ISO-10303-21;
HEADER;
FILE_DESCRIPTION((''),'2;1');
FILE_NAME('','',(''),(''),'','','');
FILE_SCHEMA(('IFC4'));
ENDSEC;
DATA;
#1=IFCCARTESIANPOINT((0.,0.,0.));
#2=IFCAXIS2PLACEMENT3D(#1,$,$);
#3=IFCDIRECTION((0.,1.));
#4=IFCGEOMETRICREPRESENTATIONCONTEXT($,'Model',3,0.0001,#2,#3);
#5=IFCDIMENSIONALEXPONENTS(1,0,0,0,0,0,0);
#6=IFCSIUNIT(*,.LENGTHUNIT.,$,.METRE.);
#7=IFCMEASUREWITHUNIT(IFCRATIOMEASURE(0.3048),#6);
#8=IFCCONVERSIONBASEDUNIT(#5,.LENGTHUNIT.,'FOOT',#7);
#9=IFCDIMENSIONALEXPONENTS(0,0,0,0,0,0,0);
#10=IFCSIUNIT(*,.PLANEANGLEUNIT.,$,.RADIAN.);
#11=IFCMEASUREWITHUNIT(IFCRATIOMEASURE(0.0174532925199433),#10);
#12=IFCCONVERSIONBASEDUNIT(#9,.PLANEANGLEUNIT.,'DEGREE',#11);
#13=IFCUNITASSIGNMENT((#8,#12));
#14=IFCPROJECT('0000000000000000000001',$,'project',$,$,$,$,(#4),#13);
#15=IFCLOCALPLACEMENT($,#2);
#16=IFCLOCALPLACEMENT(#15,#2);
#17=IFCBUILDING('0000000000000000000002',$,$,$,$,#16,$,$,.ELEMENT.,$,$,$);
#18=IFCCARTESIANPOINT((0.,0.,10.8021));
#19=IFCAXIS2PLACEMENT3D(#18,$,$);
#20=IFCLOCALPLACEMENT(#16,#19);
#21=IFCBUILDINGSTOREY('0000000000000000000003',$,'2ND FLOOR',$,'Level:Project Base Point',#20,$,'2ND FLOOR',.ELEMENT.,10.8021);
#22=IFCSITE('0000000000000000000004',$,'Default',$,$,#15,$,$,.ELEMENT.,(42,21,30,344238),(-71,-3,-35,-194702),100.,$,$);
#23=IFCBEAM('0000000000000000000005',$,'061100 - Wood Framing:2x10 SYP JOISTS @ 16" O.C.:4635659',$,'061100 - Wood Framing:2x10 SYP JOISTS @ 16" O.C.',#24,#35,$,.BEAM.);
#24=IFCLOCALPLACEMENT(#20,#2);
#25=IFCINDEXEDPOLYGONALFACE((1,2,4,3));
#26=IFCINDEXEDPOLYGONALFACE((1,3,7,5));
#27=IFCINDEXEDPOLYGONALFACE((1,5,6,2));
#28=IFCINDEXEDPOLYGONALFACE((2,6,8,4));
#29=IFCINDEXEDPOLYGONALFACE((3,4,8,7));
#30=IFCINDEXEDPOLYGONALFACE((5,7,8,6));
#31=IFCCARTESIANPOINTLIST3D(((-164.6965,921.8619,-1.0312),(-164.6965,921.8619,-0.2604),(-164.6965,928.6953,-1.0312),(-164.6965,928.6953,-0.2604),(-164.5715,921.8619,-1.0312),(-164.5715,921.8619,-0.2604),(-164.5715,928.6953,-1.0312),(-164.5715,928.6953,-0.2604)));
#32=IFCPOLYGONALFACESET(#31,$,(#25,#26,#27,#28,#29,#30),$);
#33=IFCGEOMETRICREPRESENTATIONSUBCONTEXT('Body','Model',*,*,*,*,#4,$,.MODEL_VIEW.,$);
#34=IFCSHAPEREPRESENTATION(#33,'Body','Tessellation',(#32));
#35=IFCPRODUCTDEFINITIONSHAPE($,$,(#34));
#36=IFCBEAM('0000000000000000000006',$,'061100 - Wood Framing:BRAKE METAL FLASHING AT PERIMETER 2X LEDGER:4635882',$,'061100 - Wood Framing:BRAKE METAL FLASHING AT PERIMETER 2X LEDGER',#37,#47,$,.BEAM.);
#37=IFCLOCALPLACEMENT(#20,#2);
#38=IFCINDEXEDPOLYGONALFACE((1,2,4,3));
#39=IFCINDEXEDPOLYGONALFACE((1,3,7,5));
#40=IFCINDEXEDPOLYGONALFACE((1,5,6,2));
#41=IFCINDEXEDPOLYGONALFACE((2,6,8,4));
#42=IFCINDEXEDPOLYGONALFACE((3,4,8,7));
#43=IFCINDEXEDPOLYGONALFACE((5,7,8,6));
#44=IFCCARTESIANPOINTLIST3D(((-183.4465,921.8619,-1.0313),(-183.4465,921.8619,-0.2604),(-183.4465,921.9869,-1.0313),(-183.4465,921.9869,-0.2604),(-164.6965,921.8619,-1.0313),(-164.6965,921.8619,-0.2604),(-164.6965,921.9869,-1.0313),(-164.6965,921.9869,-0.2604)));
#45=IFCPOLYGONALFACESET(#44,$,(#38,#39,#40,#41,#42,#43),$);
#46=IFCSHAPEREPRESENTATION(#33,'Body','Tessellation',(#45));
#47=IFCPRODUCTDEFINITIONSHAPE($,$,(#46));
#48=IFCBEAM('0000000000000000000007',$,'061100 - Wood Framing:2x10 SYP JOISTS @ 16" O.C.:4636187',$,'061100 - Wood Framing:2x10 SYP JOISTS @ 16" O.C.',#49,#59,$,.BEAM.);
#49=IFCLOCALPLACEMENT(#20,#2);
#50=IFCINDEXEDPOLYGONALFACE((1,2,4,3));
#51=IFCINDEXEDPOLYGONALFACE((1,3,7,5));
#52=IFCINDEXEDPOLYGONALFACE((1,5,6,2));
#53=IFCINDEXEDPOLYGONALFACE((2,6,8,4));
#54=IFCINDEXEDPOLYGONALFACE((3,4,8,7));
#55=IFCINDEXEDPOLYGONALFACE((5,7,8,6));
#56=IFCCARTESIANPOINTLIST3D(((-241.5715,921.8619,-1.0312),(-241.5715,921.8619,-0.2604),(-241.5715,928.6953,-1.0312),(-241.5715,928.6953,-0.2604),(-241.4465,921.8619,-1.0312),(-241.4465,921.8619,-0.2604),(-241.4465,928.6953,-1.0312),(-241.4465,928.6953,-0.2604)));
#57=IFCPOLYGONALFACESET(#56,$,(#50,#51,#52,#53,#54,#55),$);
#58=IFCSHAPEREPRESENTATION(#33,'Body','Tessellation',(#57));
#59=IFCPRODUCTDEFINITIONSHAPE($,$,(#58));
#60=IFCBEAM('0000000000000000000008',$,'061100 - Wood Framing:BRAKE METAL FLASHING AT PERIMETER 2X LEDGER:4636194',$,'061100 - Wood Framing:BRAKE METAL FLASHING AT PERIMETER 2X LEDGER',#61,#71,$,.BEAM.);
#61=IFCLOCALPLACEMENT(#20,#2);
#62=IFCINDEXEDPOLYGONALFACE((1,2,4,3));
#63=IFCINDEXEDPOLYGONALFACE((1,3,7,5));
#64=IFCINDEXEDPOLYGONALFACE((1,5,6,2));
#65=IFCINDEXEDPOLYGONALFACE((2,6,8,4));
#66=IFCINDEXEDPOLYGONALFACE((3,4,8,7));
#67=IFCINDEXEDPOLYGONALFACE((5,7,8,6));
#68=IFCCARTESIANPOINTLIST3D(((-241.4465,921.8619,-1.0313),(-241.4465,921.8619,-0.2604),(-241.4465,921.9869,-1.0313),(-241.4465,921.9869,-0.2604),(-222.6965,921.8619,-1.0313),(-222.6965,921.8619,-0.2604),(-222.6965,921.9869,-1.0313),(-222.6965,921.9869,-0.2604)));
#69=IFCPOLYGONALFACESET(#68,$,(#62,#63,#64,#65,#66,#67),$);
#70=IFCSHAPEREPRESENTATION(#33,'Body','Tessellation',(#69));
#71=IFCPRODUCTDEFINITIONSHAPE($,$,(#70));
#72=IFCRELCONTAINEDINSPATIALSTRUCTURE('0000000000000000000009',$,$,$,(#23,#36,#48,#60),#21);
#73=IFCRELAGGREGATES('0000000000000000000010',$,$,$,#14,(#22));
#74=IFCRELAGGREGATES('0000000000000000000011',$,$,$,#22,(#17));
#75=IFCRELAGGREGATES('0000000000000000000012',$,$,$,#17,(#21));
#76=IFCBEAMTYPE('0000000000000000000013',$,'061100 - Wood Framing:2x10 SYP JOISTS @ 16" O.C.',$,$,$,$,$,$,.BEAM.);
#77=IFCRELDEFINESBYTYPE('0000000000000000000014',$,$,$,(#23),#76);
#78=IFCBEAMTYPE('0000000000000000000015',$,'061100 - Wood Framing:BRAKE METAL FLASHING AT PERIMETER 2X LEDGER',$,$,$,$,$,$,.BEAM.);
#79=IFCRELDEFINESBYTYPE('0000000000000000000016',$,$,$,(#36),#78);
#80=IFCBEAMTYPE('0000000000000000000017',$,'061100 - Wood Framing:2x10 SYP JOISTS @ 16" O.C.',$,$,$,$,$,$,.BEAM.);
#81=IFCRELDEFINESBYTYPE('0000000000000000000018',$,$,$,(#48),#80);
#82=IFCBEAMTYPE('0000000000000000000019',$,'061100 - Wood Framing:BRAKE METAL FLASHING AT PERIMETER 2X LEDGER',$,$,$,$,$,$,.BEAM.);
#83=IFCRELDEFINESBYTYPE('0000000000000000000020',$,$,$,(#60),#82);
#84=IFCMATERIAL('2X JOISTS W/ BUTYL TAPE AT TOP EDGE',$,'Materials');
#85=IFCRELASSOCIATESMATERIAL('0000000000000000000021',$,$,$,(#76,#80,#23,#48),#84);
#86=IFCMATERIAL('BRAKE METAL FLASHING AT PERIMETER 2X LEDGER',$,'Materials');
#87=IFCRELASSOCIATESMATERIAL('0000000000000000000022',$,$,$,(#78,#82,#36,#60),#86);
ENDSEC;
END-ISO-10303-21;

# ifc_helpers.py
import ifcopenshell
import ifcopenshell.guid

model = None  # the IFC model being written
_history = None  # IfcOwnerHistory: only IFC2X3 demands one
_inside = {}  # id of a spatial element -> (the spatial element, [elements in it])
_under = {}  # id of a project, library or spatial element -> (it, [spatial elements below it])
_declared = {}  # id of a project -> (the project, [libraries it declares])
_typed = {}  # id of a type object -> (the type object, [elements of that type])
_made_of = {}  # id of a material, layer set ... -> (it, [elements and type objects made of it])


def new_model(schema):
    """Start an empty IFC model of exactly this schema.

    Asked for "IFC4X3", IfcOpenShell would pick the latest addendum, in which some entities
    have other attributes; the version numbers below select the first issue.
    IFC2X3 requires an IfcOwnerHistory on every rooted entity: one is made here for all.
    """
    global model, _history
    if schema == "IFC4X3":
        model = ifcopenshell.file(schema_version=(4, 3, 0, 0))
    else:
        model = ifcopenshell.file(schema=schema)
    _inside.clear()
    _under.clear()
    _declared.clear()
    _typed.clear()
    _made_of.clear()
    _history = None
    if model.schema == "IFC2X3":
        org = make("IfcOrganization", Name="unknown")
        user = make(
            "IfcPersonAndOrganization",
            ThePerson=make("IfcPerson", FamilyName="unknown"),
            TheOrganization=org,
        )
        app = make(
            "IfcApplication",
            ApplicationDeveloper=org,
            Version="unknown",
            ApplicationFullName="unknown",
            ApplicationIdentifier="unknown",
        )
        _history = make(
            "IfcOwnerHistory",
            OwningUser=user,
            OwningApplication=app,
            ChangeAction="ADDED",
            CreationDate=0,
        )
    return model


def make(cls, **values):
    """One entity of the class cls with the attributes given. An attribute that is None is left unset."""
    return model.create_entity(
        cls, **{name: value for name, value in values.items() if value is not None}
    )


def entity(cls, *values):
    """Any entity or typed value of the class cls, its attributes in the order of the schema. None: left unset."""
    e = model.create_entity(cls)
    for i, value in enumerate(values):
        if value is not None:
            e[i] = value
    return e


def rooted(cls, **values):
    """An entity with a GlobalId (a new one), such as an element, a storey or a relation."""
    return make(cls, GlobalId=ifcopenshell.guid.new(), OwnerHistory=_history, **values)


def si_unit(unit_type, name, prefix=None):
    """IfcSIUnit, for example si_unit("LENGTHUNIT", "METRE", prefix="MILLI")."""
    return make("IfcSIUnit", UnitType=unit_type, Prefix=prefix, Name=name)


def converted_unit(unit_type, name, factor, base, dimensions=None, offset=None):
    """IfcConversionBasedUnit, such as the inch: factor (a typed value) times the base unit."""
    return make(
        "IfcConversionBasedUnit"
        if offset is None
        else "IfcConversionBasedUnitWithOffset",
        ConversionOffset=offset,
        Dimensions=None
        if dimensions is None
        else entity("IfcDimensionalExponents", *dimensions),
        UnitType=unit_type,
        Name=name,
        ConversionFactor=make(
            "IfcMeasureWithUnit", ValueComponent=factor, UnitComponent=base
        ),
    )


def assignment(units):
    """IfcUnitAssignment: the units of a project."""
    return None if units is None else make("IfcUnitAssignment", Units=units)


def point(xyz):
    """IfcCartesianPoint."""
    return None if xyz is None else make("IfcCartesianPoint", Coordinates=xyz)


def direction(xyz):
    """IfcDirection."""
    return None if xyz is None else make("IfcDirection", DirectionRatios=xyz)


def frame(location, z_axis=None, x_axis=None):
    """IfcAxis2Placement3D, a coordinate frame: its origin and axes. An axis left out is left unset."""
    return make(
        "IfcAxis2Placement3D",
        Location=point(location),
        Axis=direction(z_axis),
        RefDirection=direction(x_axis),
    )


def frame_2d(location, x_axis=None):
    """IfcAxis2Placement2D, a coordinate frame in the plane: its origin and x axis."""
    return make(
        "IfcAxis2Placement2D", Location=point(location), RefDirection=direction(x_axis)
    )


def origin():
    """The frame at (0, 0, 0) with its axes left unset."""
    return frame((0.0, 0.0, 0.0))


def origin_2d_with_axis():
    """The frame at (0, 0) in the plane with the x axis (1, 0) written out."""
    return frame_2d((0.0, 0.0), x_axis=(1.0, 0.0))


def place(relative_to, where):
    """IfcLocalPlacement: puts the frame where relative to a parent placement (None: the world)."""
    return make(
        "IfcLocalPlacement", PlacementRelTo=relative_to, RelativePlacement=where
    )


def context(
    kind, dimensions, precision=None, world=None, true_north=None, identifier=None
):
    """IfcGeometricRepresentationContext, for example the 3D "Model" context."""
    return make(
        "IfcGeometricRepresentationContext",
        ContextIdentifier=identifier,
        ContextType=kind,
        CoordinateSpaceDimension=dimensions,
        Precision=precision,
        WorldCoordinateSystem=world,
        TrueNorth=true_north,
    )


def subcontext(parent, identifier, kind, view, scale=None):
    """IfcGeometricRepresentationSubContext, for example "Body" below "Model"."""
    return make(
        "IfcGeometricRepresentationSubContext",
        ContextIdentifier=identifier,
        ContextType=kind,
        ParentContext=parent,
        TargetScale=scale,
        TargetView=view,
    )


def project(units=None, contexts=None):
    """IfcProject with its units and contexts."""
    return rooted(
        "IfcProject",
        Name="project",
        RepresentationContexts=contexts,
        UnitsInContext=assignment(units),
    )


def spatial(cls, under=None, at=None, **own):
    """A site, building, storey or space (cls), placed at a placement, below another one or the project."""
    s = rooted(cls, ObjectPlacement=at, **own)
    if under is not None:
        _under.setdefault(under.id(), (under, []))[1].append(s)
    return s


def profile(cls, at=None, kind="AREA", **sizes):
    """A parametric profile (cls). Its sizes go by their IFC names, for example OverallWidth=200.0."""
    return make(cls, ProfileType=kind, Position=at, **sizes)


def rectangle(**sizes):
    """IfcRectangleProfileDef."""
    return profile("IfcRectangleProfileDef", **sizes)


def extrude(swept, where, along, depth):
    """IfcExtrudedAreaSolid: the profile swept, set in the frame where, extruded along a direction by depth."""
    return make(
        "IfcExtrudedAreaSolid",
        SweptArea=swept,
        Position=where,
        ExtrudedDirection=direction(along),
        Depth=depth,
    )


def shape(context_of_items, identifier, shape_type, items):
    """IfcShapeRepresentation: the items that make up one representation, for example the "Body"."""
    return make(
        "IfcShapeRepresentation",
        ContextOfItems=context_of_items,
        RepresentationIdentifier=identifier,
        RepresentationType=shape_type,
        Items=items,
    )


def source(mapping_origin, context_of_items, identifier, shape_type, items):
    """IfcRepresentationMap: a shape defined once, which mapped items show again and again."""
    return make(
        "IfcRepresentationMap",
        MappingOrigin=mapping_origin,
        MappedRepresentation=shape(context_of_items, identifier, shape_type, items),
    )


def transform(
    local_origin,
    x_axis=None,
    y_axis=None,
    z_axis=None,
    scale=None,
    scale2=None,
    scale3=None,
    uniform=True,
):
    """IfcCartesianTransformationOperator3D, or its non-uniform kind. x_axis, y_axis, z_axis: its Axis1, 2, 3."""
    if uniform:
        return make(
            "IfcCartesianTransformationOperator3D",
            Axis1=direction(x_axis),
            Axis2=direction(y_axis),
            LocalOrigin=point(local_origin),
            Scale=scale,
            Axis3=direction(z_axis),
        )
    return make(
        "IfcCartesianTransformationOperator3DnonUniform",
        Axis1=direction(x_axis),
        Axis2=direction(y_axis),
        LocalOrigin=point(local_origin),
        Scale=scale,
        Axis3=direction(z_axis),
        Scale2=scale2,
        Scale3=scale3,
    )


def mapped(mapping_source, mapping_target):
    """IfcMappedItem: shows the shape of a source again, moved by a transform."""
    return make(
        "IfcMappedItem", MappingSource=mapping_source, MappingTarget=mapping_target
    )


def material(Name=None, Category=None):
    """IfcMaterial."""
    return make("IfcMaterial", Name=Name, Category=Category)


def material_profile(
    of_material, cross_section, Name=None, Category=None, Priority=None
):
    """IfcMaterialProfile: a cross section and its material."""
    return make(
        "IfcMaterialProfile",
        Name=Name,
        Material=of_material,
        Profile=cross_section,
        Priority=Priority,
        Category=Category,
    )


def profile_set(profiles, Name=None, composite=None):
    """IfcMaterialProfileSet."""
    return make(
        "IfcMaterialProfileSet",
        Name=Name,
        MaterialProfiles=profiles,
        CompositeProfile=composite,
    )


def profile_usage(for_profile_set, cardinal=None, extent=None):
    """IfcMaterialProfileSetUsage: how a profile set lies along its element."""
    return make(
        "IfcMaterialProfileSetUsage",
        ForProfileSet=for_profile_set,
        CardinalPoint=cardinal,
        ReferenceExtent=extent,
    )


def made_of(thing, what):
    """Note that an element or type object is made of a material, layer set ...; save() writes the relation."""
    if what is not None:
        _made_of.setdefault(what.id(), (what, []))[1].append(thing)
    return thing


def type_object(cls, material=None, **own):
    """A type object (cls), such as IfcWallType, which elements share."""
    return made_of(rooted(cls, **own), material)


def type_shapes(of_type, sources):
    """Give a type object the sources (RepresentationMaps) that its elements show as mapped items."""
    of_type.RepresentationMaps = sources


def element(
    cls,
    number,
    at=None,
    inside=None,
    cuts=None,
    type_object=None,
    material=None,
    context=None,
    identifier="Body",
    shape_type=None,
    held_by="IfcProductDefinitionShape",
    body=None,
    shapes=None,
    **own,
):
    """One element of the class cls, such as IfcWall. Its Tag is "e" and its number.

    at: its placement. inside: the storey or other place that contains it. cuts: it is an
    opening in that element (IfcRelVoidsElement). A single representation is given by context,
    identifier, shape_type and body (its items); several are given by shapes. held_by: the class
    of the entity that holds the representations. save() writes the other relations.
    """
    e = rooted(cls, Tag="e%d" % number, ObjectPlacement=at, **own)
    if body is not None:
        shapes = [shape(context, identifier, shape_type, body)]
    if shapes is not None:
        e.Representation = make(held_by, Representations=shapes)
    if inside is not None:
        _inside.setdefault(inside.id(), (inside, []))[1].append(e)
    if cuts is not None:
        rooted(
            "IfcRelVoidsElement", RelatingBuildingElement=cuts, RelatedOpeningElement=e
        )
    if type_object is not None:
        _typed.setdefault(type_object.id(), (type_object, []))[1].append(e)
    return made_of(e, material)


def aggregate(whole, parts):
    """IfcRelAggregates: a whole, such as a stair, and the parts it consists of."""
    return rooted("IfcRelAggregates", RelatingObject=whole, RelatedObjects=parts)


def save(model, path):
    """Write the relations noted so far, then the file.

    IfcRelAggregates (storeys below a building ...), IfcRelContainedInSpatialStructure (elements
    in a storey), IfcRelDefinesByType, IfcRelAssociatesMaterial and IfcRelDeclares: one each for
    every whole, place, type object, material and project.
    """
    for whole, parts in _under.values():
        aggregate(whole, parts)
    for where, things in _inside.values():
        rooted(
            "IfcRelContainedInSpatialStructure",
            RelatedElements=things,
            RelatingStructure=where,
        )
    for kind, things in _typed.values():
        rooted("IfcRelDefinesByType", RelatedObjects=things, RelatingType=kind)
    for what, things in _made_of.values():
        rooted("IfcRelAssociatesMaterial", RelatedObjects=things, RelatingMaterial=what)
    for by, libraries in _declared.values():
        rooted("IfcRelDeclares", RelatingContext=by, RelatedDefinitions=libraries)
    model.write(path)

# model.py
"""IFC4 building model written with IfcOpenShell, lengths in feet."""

from ifc_helpers import new_model, entity, si_unit, converted_unit, direction, frame, frame_2d, origin, origin_2d_with_axis, place, context, subcontext, project, spatial, rectangle, extrude, source, transform, mapped, material, material_profile, profile_set, profile_usage, type_object, type_shapes, element, save


model = new_model("IFC4")

# Units and contexts
model_context = context("Model", 3, precision=0.0001, world=origin(), true_north=direction((0.0, 1.0)))
body_context = subcontext(model_context, "Body", "Model", "MODEL_VIEW")
ifc_project = project(units=[converted_unit("LENGTHUNIT", "FOOT", entity("IfcRatioMeasure", 0.3048), si_unit("LENGTHUNIT", "METRE"), dimensions=[1, 0, 0, 0, 0, 0, 0]), converted_unit("PLANEANGLEUNIT", "DEGREE", entity("IfcRatioMeasure", 0.0174532925199433), si_unit("PLANEANGLEUNIT", "RADIAN"), dimensions=[0, 0, 0, 0, 0, 0, 0])], contexts=[model_context])

# Site, building, storey
site_placement = place(None, origin())
site = spatial("IfcSite", under=ifc_project, at=site_placement, Name="Default", CompositionType="ELEMENT", RefLatitude=(42, 21, 30, 344238), RefLongitude=(-71, -3, -35, -194702), RefElevation=100.0)
building_placement = place(site_placement, origin())
building = spatial("IfcBuilding", under=site, at=building_placement, CompositionType="ELEMENT")
storey_placement = place(building_placement, frame((0.0, 0.0, 10.8021)))
storey = spatial("IfcBuildingStorey", under=building, at=storey_placement, Name="2ND FLOOR", ObjectType="Level:Project Base Point", LongName="2ND FLOOR", CompositionType="ELEMENT", Elevation=10.8021)

# Shared definitions
ifc_material_1 = material(Name="2X JOISTS W/ BUTYL TAPE AT TOP EDGE", Category="Materials")
ifc_material_profile_1 = material_profile(ifc_material_1, rectangle(XDim=0.7708, YDim=0.125, at=frame_2d((0.0, 0.0), x_axis=(1.0, 0.0))), Name="2x10 SYP JOISTS @ 16\" O.C.")
ifc_profile_set_1 = profile_set([ifc_material_profile_1], Name="2x10 SYP JOISTS @ 16\" O.C.")

# Beams
ifc_profile_usage_1 = profile_usage(ifc_profile_set_1, cardinal=8)
beam_type_1 = type_object("IfcBeamType", Name="061100 - Wood Framing:2x10 SYP JOISTS @ 16\" O.C.", PredefinedType="BEAM", material=ifc_profile_set_1)
shared_shape_1 = source(origin(), body_context, "Body", "SweptSolid", [
    extrude(rectangle(XDim=0.7708, YDim=0.125, at=frame_2d((0.0, 0.0), x_axis=(1.0, 0.0))), frame((-3.4792, 0.0, 0.0), z_axis=(1.0, 0.0, 0.0), x_axis=(0.0, 0.0, -1.0)), (0.0, 0.0, 1.0), 6.8333),
])
type_shapes(beam_type_1, [shared_shape_1])
beam_1_placement = place(storey_placement, frame((-164.634, 925.3411, -0.6458), z_axis=(0.0, 0.0, 1.0), x_axis=(0.0, 1.0, 0.0)))
element("IfcBeam", 1, at=beam_1_placement, inside=storey, type_object=beam_type_1, material=ifc_profile_usage_1, Name="061100 - Wood Framing:2x10 SYP JOISTS @ 16\" O.C.:4635659", ObjectType="061100 - Wood Framing:2x10 SYP JOISTS @ 16\" O.C.", PredefinedType="BEAM", context=body_context, shape_type="MappedRepresentation", body=[
    mapped(shared_shape_1, transform((0.0, 0.0, 0.0), scale=1.0)),
])
ifc_material_2 = material(Name="BRAKE METAL FLASHING AT PERIMETER 2X LEDGER", Category="Materials")
ifc_material_profile_2 = material_profile(ifc_material_2, rectangle(XDim=0.7708, YDim=0.125, at=frame_2d((0.0, 0.0), x_axis=(1.0, 0.0))), Name="BRAKE METAL FLASHING AT PERIMETER 2X LEDGER")
ifc_profile_set_2 = profile_set([ifc_material_profile_2], Name="BRAKE METAL FLASHING AT PERIMETER 2X LEDGER")
ifc_profile_usage_2 = profile_usage(ifc_profile_set_2, cardinal=8)
beam_type_2 = type_object("IfcBeamType", Name="061100 - Wood Framing:BRAKE METAL FLASHING AT PERIMETER 2X LEDGER", PredefinedType="BEAM", material=ifc_profile_set_2)
shared_shape_2 = source(origin(), body_context, "Body", "SweptSolid", [
    extrude(rectangle(XDim=0.7708, YDim=0.125, at=frame_2d((0.0, 0.0), x_axis=(1.0, 0.0))), frame((-9.375, 0.0, 0.0), z_axis=(1.0, 0.0, 0.0), x_axis=(0.0, 0.0, -1.0)), (0.0, 0.0, 1.0), 18.75),
])
type_shapes(beam_type_2, [shared_shape_2])
beam_2_placement = place(storey_placement, frame((-174.0715, 921.9244, -0.6458)))
element("IfcBeam", 2, at=beam_2_placement, inside=storey, type_object=beam_type_2, material=ifc_profile_usage_2, Name="061100 - Wood Framing:BRAKE METAL FLASHING AT PERIMETER 2X LEDGER:4635882", ObjectType="061100 - Wood Framing:BRAKE METAL FLASHING AT PERIMETER 2X LEDGER", PredefinedType="BEAM", context=body_context, shape_type="MappedRepresentation", body=[
    mapped(shared_shape_2, transform((0.0, 0.0, 0.0), scale=1.0)),
])
ifc_profile_usage_3 = profile_usage(ifc_profile_set_1, cardinal=8)
beam_type_3 = type_object("IfcBeamType", Name="061100 - Wood Framing:2x10 SYP JOISTS @ 16\" O.C.", PredefinedType="BEAM", material=ifc_profile_set_1)
shared_shape_3 = source(origin(), body_context, "Body", "SweptSolid", [
    extrude(rectangle(XDim=0.7708, YDim=0.125, at=origin_2d_with_axis()), frame((-3.4792, 0.0, 0.0), z_axis=(1.0, 0.0, 0.0), x_axis=(0.0, 0.0, -1.0)), (0.0, 0.0, 1.0), 6.8333),
])
type_shapes(beam_type_3, [shared_shape_3])
beam_3_placement = place(storey_placement, frame((-241.509, 925.3411, -0.6458), z_axis=(0.0, 0.0, 1.0), x_axis=(0.0, 1.0, 0.0)))
element("IfcBeam", 3, at=beam_3_placement, inside=storey, type_object=beam_type_3, material=ifc_profile_usage_3, Name="061100 - Wood Framing:2x10 SYP JOISTS @ 16\" O.C.:4636187", ObjectType="061100 - Wood Framing:2x10 SYP JOISTS @ 16\" O.C.", PredefinedType="BEAM", context=body_context, shape_type="MappedRepresentation", body=[
    mapped(shared_shape_3, transform((0.0, 0.0, 0.0), scale=1.0)),
])
ifc_profile_usage_4 = profile_usage(ifc_profile_set_2, cardinal=8)
beam_type_4 = type_object("IfcBeamType", Name="061100 - Wood Framing:BRAKE METAL FLASHING AT PERIMETER 2X LEDGER", PredefinedType="BEAM", material=ifc_profile_set_2)
shared_shape_4 = source(origin(), body_context, "Body", "SweptSolid", [
    extrude(rectangle(XDim=0.7708, YDim=0.125, at=origin_2d_with_axis()), frame((-9.375, 0.0, 0.0), z_axis=(1.0, 0.0, 0.0), x_axis=(0.0, 0.0, -1.0)), (0.0, 0.0, 1.0), 18.75),
])
type_shapes(beam_type_4, [shared_shape_4])
beam_4_placement = place(storey_placement, frame((-232.0715, 921.9244, -0.6458), z_axis=(0.0, 0.0, 1.0), x_axis=(-1.0, 0.0, 0.0)))
element("IfcBeam", 4, at=beam_4_placement, inside=storey, type_object=beam_type_4, material=ifc_profile_usage_4, Name="061100 - Wood Framing:BRAKE METAL FLASHING AT PERIMETER 2X LEDGER:4636194", ObjectType="061100 - Wood Framing:BRAKE METAL FLASHING AT PERIMETER 2X LEDGER", PredefinedType="BEAM", context=body_context, shape_type="MappedRepresentation", body=[
    mapped(shared_shape_4, transform((0.0, 0.0, 0.0), scale=1.0)),
])

save(model, "model.ifc")
